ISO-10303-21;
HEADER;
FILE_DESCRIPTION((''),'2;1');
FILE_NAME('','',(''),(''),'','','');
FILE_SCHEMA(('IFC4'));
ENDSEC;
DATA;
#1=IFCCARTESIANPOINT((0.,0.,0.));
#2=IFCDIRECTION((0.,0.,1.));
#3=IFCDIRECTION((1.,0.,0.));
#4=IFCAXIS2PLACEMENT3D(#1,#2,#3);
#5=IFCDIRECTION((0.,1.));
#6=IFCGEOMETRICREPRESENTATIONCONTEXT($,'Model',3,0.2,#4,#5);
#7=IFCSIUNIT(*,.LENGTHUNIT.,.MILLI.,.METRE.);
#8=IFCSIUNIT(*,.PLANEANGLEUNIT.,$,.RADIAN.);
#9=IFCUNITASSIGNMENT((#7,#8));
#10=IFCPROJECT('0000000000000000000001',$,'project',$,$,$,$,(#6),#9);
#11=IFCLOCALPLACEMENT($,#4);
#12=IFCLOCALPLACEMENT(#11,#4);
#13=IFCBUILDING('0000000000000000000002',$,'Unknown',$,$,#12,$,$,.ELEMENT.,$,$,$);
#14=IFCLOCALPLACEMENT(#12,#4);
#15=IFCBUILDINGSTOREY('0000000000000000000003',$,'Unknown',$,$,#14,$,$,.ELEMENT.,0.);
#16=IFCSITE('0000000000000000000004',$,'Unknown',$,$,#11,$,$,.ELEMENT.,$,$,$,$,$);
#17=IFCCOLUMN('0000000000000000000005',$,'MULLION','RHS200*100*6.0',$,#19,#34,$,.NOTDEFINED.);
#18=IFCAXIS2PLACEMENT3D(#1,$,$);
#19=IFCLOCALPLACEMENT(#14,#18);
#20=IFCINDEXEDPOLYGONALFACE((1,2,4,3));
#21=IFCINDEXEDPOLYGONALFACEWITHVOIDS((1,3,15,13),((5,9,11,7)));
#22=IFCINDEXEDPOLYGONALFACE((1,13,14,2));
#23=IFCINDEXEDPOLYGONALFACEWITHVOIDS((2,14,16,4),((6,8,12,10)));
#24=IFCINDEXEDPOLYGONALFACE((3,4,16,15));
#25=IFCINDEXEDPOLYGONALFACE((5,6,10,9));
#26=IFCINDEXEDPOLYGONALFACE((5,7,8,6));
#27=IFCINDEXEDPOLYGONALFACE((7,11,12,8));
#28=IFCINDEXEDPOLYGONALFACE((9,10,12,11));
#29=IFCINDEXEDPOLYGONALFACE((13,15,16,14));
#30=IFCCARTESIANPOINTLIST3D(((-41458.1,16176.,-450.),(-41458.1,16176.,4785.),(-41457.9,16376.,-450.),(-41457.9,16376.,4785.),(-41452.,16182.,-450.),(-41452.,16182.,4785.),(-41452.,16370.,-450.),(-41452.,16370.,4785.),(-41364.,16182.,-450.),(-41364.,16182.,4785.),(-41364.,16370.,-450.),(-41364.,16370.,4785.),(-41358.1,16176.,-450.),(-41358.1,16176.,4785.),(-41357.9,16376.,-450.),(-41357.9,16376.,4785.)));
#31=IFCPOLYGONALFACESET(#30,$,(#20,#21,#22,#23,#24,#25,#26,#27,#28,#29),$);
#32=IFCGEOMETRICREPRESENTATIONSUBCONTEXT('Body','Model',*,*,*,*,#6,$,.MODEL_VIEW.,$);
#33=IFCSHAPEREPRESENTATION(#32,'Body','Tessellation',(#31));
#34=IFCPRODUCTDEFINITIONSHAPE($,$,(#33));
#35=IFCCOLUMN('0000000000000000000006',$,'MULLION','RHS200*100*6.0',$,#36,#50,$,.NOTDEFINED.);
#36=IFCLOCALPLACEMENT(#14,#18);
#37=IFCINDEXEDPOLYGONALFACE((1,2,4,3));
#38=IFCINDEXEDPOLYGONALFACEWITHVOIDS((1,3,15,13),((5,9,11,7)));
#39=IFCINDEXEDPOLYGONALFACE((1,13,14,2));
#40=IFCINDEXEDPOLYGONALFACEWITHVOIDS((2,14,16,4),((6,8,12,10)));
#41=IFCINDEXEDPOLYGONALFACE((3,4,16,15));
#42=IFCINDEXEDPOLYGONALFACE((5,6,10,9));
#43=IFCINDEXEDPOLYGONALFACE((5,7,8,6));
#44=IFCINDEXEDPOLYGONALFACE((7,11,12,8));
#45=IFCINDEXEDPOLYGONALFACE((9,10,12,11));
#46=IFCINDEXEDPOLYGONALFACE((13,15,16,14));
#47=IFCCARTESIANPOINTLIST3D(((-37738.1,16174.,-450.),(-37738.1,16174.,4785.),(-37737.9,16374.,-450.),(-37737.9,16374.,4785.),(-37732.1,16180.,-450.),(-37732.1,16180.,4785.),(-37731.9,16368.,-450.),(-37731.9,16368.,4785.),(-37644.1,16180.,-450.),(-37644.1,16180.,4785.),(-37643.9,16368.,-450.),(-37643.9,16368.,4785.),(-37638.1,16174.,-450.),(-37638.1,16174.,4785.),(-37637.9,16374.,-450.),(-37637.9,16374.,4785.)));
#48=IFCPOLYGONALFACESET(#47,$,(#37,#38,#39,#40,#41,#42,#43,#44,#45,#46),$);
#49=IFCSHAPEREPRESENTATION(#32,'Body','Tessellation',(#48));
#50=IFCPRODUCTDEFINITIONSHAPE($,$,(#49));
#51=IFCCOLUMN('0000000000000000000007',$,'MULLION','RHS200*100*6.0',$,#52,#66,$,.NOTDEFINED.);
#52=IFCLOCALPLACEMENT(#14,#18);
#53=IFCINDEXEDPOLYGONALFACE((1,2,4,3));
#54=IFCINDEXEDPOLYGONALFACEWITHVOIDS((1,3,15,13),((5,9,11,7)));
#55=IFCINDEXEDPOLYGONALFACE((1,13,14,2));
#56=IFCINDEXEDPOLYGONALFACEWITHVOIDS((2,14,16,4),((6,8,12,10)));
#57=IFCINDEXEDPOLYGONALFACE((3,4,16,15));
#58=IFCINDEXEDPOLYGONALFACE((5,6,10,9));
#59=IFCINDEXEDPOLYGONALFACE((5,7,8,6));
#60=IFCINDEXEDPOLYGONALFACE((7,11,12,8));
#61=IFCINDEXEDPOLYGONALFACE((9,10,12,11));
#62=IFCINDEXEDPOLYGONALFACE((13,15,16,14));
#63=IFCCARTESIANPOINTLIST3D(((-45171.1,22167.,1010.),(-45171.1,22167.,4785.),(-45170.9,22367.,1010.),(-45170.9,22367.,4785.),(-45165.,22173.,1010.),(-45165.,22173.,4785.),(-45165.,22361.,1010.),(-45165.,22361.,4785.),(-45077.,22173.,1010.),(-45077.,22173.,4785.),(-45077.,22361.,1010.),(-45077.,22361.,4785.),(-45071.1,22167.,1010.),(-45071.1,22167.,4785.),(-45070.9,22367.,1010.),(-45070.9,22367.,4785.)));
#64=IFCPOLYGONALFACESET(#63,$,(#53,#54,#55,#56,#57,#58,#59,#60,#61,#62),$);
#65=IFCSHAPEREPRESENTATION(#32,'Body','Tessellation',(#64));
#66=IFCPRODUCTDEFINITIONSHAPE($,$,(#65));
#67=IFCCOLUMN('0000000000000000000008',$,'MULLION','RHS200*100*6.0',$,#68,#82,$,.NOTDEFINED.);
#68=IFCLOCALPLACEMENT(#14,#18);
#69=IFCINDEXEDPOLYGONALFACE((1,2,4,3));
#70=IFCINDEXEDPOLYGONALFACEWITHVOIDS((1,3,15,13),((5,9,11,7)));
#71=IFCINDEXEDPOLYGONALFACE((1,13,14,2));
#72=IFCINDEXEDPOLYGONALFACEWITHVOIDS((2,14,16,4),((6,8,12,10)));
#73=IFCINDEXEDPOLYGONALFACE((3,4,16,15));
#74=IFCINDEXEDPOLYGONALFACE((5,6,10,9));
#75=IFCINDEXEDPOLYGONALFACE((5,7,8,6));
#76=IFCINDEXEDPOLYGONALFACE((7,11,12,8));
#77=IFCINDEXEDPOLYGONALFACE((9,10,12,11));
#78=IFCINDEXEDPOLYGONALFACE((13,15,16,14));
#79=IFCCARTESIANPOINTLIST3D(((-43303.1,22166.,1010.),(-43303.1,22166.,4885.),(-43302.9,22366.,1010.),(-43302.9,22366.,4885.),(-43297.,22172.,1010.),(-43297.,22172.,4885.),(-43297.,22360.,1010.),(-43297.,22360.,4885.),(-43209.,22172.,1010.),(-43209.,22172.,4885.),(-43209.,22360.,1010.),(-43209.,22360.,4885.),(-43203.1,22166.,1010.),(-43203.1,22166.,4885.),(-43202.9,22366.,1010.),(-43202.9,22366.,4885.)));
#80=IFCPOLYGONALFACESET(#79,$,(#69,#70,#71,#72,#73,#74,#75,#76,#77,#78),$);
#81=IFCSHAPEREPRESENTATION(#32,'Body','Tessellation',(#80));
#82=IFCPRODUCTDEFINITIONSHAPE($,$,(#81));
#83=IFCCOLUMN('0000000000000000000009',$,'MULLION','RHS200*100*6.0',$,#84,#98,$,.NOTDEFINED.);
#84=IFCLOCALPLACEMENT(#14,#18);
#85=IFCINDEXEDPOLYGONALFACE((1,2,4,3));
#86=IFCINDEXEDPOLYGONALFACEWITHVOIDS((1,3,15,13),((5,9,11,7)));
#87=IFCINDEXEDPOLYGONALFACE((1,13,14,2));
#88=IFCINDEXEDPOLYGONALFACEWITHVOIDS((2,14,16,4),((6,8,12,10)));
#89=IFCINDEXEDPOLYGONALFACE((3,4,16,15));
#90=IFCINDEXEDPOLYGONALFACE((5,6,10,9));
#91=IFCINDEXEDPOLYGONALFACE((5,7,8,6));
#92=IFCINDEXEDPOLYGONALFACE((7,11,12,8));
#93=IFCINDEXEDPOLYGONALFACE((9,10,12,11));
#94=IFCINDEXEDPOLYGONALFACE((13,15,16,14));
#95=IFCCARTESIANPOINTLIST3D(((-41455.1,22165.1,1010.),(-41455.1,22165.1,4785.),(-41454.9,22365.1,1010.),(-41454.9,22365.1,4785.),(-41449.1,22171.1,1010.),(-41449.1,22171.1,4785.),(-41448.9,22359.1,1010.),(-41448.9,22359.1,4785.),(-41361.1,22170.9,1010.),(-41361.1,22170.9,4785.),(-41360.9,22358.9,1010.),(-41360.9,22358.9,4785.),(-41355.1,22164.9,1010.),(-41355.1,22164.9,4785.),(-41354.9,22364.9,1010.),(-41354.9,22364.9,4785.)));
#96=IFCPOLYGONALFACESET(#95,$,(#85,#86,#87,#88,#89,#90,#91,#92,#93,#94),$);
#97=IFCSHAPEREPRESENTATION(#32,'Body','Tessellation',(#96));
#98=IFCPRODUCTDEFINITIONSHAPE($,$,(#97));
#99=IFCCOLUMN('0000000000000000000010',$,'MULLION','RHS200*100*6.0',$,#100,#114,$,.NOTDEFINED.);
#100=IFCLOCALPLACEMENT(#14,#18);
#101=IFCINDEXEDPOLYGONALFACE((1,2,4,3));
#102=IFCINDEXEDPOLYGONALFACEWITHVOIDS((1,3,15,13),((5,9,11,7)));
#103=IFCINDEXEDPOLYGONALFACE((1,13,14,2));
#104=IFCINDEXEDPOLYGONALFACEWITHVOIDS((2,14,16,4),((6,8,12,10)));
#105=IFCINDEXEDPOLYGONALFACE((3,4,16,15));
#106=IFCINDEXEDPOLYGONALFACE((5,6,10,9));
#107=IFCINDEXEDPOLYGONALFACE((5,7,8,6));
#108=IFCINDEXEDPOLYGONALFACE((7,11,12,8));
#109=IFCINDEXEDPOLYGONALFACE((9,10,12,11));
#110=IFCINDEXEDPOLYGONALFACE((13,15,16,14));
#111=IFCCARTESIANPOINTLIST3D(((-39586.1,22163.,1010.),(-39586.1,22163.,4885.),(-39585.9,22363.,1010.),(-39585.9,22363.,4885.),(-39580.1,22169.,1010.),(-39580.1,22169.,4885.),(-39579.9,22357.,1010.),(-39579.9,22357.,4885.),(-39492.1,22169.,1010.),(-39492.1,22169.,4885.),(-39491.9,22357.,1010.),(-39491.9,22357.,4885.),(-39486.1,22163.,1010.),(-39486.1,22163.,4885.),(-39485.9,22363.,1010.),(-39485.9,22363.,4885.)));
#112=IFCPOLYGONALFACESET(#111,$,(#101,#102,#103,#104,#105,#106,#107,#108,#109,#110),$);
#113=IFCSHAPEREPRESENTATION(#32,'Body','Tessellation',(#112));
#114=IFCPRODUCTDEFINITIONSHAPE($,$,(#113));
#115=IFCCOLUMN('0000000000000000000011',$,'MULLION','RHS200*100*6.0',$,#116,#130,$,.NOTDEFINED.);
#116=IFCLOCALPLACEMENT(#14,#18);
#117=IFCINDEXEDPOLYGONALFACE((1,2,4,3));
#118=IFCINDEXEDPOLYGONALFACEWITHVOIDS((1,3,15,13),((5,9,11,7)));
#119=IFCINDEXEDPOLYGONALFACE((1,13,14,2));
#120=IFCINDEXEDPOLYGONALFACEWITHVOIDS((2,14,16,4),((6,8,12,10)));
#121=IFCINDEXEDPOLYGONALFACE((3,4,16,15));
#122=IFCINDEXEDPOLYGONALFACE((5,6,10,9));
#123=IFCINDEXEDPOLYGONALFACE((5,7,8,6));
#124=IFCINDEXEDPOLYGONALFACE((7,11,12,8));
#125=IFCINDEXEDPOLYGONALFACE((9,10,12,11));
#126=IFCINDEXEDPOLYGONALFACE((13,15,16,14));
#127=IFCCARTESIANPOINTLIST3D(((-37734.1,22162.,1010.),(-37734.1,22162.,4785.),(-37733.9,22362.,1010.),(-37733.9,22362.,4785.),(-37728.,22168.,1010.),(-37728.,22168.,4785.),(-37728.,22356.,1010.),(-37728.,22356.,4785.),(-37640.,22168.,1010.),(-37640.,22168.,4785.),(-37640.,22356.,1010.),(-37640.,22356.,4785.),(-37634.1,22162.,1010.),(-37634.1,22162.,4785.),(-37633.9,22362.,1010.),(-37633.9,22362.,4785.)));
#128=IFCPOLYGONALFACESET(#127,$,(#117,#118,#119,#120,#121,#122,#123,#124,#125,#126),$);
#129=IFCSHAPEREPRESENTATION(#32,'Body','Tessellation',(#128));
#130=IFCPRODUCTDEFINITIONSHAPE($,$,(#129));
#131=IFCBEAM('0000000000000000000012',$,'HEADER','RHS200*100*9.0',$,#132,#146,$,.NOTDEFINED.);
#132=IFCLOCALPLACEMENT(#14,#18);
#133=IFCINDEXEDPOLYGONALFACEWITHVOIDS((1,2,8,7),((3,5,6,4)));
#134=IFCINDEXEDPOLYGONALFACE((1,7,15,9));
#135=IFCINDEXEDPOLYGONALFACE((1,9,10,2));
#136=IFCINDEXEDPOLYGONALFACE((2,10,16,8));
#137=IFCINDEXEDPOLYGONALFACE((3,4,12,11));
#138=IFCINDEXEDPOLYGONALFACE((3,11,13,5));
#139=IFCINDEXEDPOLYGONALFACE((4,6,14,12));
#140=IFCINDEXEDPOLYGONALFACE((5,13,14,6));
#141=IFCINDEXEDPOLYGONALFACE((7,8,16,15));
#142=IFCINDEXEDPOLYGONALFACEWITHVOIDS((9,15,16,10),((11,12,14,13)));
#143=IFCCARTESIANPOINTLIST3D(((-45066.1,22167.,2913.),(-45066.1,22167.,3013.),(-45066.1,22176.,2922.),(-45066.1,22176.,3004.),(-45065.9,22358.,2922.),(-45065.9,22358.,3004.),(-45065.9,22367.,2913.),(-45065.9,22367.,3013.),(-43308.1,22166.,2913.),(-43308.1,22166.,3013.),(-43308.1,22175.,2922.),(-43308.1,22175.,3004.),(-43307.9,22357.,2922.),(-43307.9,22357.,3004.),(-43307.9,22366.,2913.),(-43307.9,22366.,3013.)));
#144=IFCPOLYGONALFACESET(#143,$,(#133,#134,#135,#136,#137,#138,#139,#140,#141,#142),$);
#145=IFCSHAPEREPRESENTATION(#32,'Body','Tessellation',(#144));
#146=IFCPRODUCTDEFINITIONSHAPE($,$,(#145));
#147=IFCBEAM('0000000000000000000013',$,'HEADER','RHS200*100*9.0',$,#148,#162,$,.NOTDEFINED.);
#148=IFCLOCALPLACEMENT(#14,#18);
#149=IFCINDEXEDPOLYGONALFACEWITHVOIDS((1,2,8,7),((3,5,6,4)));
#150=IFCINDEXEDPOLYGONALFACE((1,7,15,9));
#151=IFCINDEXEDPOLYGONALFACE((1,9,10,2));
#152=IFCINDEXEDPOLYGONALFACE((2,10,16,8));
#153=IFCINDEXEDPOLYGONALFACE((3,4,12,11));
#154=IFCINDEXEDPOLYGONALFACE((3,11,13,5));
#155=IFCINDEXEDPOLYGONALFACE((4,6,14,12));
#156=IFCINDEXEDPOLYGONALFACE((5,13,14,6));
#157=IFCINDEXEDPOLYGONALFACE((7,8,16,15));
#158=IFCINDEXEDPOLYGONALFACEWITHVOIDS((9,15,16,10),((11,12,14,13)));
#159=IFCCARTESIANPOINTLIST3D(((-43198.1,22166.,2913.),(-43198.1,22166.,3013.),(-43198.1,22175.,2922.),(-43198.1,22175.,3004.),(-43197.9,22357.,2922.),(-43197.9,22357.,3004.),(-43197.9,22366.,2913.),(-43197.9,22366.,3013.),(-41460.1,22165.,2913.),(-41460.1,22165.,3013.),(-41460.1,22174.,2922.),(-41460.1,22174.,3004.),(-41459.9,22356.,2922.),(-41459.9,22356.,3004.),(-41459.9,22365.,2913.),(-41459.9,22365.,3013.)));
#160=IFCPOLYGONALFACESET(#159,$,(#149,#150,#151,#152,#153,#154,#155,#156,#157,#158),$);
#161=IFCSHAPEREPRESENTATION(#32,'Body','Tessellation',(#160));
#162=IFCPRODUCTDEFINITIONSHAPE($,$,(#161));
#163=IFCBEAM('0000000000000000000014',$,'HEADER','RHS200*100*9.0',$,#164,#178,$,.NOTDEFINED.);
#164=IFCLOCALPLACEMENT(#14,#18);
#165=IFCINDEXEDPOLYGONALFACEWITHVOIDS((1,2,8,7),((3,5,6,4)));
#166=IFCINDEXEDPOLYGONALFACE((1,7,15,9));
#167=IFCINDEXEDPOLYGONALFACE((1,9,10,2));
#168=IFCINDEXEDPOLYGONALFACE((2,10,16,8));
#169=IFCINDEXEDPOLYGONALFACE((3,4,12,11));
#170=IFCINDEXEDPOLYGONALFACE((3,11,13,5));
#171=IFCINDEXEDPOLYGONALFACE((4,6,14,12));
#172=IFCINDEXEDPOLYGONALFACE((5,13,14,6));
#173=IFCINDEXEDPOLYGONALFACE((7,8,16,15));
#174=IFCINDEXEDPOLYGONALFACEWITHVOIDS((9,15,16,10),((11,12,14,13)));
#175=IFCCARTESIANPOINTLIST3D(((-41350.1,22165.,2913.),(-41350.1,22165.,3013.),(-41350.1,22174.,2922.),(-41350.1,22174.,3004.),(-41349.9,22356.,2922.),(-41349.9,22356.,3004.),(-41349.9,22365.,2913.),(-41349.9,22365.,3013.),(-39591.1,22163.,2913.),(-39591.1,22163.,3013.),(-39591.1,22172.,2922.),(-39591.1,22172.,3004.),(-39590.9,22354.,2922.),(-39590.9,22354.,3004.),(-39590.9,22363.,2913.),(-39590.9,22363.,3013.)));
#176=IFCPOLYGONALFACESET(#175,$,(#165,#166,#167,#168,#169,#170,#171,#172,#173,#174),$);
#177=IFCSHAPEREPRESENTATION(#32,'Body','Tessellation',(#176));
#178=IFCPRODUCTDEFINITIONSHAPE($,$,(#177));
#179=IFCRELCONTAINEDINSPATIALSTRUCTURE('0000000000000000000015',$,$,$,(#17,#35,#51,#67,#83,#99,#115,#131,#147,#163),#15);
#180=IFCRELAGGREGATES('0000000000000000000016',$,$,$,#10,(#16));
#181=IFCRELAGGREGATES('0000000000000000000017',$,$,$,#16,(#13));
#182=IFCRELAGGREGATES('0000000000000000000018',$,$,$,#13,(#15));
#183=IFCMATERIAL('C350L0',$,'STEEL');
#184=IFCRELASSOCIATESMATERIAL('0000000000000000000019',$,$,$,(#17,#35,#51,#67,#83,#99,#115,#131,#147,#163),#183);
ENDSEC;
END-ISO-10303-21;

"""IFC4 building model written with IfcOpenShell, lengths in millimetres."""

from ifc_helpers import new_model, si_unit, direction, frame, origin_with_axes, place, context, subcontext, project, spatial, line, indexed_curve, outline, extrude, material, element, save


model = new_model("IFC4")

# Units and contexts
model_context = context("Model", 3, precision=0.2, world=origin_with_axes(), true_north=direction((0.0, 1.0)))
body_context = subcontext(model_context, "Body", "Model", "MODEL_VIEW")
ifc_project = project(units=[si_unit("LENGTHUNIT", "METRE", prefix="MILLI"), si_unit("PLANEANGLEUNIT", "RADIAN")], contexts=[model_context])

# Site, building, storey
site_placement = place(None, origin_with_axes())
site = spatial("IfcSite", under=ifc_project, at=site_placement, Name="Unknown", CompositionType="ELEMENT")
building_placement = place(site_placement, origin_with_axes())
building = spatial("IfcBuilding", under=site, at=building_placement, Name="Unknown", CompositionType="ELEMENT")
storey_placement = place(building_placement, origin_with_axes())
storey = spatial("IfcBuildingStorey", under=building, at=storey_placement, Name="Unknown", CompositionType="ELEMENT", Elevation=0.0)

# Columns
ifc_material_1 = material(Name="C350L0", Category="STEEL")
for number, where, z_axis, x_axis, name in (
    (1, (-41408.0, 16276.0, -450.0), (1.0, -0.000524, 0.0), (0.0, 0.0, 1.0), "MULLION"),
    (2, (-37688.0, 16274.0, -450.0), (1.0, -0.000873, 0.0), (0.0, 0.0, 1.0), "MULLION"),
):
    element("IfcColumn", number, at=place(storey_placement, frame(where, z_axis=z_axis, x_axis=x_axis)), inside=storey, material=ifc_material_1, Name=name, Description="RHS200*100*6.0", PredefinedType="NOTDEFINED", context=body_context, shape_type="SolidModel", body=[
        extrude(outline(indexed_curve([(-50.0, -100.0), (50.0, -100.0), (50.0, 100.0), (-50.0, 100.0)], segments=[line(1, 2, 3, 4, 1)]), holes=[indexed_curve([(-44.0, -94.0), (-44.0, 94.0), (44.0, 94.0), (44.0, -94.0)], segments=[line(1, 2, 3, 4, 1)])]), frame((0.0, 0.0, 0.0), z_axis=(-1.0, 0.0, 0.0), x_axis=(0.0, 0.0, 1.0)), (0.0, 0.0, -1.0), 5235.0),
    ])
column_1_placement = place(storey_placement, frame((-45121.0, 22267.0, 1010.0), z_axis=(1.0, -0.000524, 0.0), x_axis=(0.0, 0.0, 1.0)))
element("IfcColumn", 3, at=column_1_placement, inside=storey, material=ifc_material_1, Name="MULLION", Description="RHS200*100*6.0", PredefinedType="NOTDEFINED", context=body_context, shape_type="SolidModel", body=[
    extrude(outline(indexed_curve([(-50.0, -100.0), (50.0, -100.0), (50.0, 100.0), (-50.0, 100.0)], segments=[line(1, 2, 3, 4, 1)]), holes=[indexed_curve([(-44.0, -94.0), (-44.0, 94.0), (44.0, 94.0), (44.0, -94.0)], segments=[line(1, 2, 3, 4, 1)])]), frame((0.0, 0.0, 0.0), z_axis=(-1.0, 0.0, 0.0), x_axis=(0.0, 0.0, 1.0)), (0.0, 0.0, -1.0), 3775.0),
])
column_2_placement = place(storey_placement, frame((-43253.0, 22266.0, 1010.0), z_axis=(1.0, -0.000524, 0.0), x_axis=(0.0, 0.0, 1.0)))
element("IfcColumn", 4, at=column_2_placement, inside=storey, material=ifc_material_1, Name="MULLION", Description="RHS200*100*6.0", PredefinedType="NOTDEFINED", context=body_context, shape_type="SolidModel", body=[
    extrude(outline(indexed_curve([(-50.0, -100.0), (50.0, -100.0), (50.0, 100.0), (-50.0, 100.0)], segments=[line(1, 2, 3, 4, 1)]), holes=[indexed_curve([(-44.0, -94.0), (-44.0, 94.0), (44.0, 94.0), (44.0, -94.0)], segments=[line(1, 2, 3, 4, 1)])]), frame((0.0, 0.0, 0.0), z_axis=(-1.0, 0.0, 0.0), x_axis=(0.0, 0.0, 1.0)), (0.0, 0.0, -1.0), 3875.0),
])
column_3_placement = place(storey_placement, frame((-41405.0, 22265.0, 1010.0), z_axis=(0.999999, -0.001222, 0.0), x_axis=(0.0, 0.0, 1.0)))
element("IfcColumn", 5, at=column_3_placement, inside=storey, material=ifc_material_1, Name="MULLION", Description="RHS200*100*6.0", PredefinedType="NOTDEFINED", context=body_context, shape_type="SolidModel", body=[
    extrude(outline(indexed_curve([(-50.0, -100.0), (50.0, -100.0), (50.0, 100.0), (-50.0, 100.0)], segments=[line(1, 2, 3, 4, 1)]), holes=[indexed_curve([(-44.0, -94.0), (-44.0, 94.0), (44.0, 94.0), (44.0, -94.0)], segments=[line(1, 2, 3, 4, 1)])]), frame((0.0, 0.0, 0.0), z_axis=(-1.0, 0.0, 0.0), x_axis=(0.0, 0.0, 1.0)), (0.0, 0.0, -1.0), 3775.0),
])
column_4_placement = place(storey_placement, frame((-39536.0, 22263.0, 1010.0), z_axis=(1.0, -0.000873, 0.0), x_axis=(0.0, 0.0, 1.0)))
element("IfcColumn", 6, at=column_4_placement, inside=storey, material=ifc_material_1, Name="MULLION", Description="RHS200*100*6.0", PredefinedType="NOTDEFINED", context=body_context, shape_type="SolidModel", body=[
    extrude(outline(indexed_curve([(-50.0, -100.0), (50.0, -100.0), (50.0, 100.0), (-50.0, 100.0)], segments=[line(1, 2, 3, 4, 1)]), holes=[indexed_curve([(-44.0, -94.0), (-44.0, 94.0), (44.0, 94.0), (44.0, -94.0)], segments=[line(1, 2, 3, 4, 1)])]), frame((0.0, 0.0, 0.0), z_axis=(-1.0, 0.0, 0.0), x_axis=(0.0, 0.0, 1.0)), (0.0, 0.0, -1.0), 3875.0),
])
column_5_placement = place(storey_placement, frame((-37684.0, 22262.0, 1010.0), z_axis=(1.0, -0.000524, 0.0), x_axis=(0.0, 0.0, 1.0)))
element("IfcColumn", 7, at=column_5_placement, inside=storey, material=ifc_material_1, Name="MULLION", Description="RHS200*100*6.0", PredefinedType="NOTDEFINED", context=body_context, shape_type="SolidModel", body=[
    extrude(outline(indexed_curve([(-50.0, -100.0), (50.0, -100.0), (50.0, 100.0), (-50.0, 100.0)], segments=[line(1, 2, 3, 4, 1)]), holes=[indexed_curve([(-44.0, -94.0), (-44.0, 94.0), (44.0, 94.0), (44.0, -94.0)], segments=[line(1, 2, 3, 4, 1)])]), frame((0.0, 0.0, 0.0), z_axis=(-1.0, 0.0, 0.0), x_axis=(0.0, 0.0, 1.0)), (0.0, 0.0, -1.0), 3775.0),
])

# Beams
beam_1_placement = place(storey_placement, frame((-43308.0, 22266.0, 2963.0), z_axis=(0.0, 0.0, 1.0), x_axis=(-1.0, 0.000569, 0.0)))
element("IfcBeam", 8, at=beam_1_placement, inside=storey, material=ifc_material_1, Name="HEADER", Description="RHS200*100*9.0", PredefinedType="NOTDEFINED", context=body_context, shape_type="SolidModel", body=[
    extrude(outline(indexed_curve([(-50.0, -100.0), (50.0, -100.0), (50.0, 100.0), (-50.0, 100.0)], segments=[line(1, 2, 3, 4, 1)]), holes=[indexed_curve([(-41.0, -91.0), (-41.0, 91.0), (41.0, 91.0), (41.0, -91.0)], segments=[line(1, 2, 3, 4, 1)])]), frame((0.0, 0.0, 0.0), z_axis=(-1.0, 0.0, 0.0), x_axis=(0.0, 0.0, 1.0)), (0.0, 0.0, -1.0), 1758.0),
])
beam_2_placement = place(storey_placement, frame((-41460.0, 22265.0, 2963.0), z_axis=(0.0, 0.0, 1.0), x_axis=(-1.0, 0.000575, 0.0)))
element("IfcBeam", 9, at=beam_2_placement, inside=storey, material=ifc_material_1, Name="HEADER", Description="RHS200*100*9.0", PredefinedType="NOTDEFINED", context=body_context, shape_type="SolidModel", body=[
    extrude(outline(indexed_curve([(-50.0, -100.0), (50.0, -100.0), (50.0, 100.0), (-50.0, 100.0)], segments=[line(1, 2, 3, 4, 1)]), holes=[indexed_curve([(-41.0, -91.0), (-41.0, 91.0), (41.0, 91.0), (41.0, -91.0)], segments=[line(1, 2, 3, 4, 1)])]), frame((0.0, 0.0, 0.0), z_axis=(-1.0, 0.0, 0.0), x_axis=(0.0, 0.0, 1.0)), (0.0, 0.0, -1.0), 1738.0),
])
beam_3_placement = place(storey_placement, frame((-39591.0, 22263.0, 2963.0), z_axis=(0.0, 0.0, 1.0), x_axis=(-0.999999, 0.001137, 0.0)))
element("IfcBeam", 10, at=beam_3_placement, inside=storey, material=ifc_material_1, Name="HEADER", Description="RHS200*100*9.0", PredefinedType="NOTDEFINED", context=body_context, shape_type="SolidModel", body=[
    extrude(outline(indexed_curve([(-50.0, -100.0), (50.0, -100.0), (50.0, 100.0), (-50.0, 100.0)], segments=[line(1, 2, 3, 4, 1)]), holes=[indexed_curve([(-41.0, -91.0), (-41.0, 91.0), (41.0, 91.0), (41.0, -91.0)], segments=[line(1, 2, 3, 4, 1)])]), frame((0.0, 0.0, 0.0), z_axis=(-1.0, 0.0, 0.0), x_axis=(0.0, 0.0, 1.0)), (0.0, 0.0, -1.0), 1759.0),
])

save(model, "model.ifc")
